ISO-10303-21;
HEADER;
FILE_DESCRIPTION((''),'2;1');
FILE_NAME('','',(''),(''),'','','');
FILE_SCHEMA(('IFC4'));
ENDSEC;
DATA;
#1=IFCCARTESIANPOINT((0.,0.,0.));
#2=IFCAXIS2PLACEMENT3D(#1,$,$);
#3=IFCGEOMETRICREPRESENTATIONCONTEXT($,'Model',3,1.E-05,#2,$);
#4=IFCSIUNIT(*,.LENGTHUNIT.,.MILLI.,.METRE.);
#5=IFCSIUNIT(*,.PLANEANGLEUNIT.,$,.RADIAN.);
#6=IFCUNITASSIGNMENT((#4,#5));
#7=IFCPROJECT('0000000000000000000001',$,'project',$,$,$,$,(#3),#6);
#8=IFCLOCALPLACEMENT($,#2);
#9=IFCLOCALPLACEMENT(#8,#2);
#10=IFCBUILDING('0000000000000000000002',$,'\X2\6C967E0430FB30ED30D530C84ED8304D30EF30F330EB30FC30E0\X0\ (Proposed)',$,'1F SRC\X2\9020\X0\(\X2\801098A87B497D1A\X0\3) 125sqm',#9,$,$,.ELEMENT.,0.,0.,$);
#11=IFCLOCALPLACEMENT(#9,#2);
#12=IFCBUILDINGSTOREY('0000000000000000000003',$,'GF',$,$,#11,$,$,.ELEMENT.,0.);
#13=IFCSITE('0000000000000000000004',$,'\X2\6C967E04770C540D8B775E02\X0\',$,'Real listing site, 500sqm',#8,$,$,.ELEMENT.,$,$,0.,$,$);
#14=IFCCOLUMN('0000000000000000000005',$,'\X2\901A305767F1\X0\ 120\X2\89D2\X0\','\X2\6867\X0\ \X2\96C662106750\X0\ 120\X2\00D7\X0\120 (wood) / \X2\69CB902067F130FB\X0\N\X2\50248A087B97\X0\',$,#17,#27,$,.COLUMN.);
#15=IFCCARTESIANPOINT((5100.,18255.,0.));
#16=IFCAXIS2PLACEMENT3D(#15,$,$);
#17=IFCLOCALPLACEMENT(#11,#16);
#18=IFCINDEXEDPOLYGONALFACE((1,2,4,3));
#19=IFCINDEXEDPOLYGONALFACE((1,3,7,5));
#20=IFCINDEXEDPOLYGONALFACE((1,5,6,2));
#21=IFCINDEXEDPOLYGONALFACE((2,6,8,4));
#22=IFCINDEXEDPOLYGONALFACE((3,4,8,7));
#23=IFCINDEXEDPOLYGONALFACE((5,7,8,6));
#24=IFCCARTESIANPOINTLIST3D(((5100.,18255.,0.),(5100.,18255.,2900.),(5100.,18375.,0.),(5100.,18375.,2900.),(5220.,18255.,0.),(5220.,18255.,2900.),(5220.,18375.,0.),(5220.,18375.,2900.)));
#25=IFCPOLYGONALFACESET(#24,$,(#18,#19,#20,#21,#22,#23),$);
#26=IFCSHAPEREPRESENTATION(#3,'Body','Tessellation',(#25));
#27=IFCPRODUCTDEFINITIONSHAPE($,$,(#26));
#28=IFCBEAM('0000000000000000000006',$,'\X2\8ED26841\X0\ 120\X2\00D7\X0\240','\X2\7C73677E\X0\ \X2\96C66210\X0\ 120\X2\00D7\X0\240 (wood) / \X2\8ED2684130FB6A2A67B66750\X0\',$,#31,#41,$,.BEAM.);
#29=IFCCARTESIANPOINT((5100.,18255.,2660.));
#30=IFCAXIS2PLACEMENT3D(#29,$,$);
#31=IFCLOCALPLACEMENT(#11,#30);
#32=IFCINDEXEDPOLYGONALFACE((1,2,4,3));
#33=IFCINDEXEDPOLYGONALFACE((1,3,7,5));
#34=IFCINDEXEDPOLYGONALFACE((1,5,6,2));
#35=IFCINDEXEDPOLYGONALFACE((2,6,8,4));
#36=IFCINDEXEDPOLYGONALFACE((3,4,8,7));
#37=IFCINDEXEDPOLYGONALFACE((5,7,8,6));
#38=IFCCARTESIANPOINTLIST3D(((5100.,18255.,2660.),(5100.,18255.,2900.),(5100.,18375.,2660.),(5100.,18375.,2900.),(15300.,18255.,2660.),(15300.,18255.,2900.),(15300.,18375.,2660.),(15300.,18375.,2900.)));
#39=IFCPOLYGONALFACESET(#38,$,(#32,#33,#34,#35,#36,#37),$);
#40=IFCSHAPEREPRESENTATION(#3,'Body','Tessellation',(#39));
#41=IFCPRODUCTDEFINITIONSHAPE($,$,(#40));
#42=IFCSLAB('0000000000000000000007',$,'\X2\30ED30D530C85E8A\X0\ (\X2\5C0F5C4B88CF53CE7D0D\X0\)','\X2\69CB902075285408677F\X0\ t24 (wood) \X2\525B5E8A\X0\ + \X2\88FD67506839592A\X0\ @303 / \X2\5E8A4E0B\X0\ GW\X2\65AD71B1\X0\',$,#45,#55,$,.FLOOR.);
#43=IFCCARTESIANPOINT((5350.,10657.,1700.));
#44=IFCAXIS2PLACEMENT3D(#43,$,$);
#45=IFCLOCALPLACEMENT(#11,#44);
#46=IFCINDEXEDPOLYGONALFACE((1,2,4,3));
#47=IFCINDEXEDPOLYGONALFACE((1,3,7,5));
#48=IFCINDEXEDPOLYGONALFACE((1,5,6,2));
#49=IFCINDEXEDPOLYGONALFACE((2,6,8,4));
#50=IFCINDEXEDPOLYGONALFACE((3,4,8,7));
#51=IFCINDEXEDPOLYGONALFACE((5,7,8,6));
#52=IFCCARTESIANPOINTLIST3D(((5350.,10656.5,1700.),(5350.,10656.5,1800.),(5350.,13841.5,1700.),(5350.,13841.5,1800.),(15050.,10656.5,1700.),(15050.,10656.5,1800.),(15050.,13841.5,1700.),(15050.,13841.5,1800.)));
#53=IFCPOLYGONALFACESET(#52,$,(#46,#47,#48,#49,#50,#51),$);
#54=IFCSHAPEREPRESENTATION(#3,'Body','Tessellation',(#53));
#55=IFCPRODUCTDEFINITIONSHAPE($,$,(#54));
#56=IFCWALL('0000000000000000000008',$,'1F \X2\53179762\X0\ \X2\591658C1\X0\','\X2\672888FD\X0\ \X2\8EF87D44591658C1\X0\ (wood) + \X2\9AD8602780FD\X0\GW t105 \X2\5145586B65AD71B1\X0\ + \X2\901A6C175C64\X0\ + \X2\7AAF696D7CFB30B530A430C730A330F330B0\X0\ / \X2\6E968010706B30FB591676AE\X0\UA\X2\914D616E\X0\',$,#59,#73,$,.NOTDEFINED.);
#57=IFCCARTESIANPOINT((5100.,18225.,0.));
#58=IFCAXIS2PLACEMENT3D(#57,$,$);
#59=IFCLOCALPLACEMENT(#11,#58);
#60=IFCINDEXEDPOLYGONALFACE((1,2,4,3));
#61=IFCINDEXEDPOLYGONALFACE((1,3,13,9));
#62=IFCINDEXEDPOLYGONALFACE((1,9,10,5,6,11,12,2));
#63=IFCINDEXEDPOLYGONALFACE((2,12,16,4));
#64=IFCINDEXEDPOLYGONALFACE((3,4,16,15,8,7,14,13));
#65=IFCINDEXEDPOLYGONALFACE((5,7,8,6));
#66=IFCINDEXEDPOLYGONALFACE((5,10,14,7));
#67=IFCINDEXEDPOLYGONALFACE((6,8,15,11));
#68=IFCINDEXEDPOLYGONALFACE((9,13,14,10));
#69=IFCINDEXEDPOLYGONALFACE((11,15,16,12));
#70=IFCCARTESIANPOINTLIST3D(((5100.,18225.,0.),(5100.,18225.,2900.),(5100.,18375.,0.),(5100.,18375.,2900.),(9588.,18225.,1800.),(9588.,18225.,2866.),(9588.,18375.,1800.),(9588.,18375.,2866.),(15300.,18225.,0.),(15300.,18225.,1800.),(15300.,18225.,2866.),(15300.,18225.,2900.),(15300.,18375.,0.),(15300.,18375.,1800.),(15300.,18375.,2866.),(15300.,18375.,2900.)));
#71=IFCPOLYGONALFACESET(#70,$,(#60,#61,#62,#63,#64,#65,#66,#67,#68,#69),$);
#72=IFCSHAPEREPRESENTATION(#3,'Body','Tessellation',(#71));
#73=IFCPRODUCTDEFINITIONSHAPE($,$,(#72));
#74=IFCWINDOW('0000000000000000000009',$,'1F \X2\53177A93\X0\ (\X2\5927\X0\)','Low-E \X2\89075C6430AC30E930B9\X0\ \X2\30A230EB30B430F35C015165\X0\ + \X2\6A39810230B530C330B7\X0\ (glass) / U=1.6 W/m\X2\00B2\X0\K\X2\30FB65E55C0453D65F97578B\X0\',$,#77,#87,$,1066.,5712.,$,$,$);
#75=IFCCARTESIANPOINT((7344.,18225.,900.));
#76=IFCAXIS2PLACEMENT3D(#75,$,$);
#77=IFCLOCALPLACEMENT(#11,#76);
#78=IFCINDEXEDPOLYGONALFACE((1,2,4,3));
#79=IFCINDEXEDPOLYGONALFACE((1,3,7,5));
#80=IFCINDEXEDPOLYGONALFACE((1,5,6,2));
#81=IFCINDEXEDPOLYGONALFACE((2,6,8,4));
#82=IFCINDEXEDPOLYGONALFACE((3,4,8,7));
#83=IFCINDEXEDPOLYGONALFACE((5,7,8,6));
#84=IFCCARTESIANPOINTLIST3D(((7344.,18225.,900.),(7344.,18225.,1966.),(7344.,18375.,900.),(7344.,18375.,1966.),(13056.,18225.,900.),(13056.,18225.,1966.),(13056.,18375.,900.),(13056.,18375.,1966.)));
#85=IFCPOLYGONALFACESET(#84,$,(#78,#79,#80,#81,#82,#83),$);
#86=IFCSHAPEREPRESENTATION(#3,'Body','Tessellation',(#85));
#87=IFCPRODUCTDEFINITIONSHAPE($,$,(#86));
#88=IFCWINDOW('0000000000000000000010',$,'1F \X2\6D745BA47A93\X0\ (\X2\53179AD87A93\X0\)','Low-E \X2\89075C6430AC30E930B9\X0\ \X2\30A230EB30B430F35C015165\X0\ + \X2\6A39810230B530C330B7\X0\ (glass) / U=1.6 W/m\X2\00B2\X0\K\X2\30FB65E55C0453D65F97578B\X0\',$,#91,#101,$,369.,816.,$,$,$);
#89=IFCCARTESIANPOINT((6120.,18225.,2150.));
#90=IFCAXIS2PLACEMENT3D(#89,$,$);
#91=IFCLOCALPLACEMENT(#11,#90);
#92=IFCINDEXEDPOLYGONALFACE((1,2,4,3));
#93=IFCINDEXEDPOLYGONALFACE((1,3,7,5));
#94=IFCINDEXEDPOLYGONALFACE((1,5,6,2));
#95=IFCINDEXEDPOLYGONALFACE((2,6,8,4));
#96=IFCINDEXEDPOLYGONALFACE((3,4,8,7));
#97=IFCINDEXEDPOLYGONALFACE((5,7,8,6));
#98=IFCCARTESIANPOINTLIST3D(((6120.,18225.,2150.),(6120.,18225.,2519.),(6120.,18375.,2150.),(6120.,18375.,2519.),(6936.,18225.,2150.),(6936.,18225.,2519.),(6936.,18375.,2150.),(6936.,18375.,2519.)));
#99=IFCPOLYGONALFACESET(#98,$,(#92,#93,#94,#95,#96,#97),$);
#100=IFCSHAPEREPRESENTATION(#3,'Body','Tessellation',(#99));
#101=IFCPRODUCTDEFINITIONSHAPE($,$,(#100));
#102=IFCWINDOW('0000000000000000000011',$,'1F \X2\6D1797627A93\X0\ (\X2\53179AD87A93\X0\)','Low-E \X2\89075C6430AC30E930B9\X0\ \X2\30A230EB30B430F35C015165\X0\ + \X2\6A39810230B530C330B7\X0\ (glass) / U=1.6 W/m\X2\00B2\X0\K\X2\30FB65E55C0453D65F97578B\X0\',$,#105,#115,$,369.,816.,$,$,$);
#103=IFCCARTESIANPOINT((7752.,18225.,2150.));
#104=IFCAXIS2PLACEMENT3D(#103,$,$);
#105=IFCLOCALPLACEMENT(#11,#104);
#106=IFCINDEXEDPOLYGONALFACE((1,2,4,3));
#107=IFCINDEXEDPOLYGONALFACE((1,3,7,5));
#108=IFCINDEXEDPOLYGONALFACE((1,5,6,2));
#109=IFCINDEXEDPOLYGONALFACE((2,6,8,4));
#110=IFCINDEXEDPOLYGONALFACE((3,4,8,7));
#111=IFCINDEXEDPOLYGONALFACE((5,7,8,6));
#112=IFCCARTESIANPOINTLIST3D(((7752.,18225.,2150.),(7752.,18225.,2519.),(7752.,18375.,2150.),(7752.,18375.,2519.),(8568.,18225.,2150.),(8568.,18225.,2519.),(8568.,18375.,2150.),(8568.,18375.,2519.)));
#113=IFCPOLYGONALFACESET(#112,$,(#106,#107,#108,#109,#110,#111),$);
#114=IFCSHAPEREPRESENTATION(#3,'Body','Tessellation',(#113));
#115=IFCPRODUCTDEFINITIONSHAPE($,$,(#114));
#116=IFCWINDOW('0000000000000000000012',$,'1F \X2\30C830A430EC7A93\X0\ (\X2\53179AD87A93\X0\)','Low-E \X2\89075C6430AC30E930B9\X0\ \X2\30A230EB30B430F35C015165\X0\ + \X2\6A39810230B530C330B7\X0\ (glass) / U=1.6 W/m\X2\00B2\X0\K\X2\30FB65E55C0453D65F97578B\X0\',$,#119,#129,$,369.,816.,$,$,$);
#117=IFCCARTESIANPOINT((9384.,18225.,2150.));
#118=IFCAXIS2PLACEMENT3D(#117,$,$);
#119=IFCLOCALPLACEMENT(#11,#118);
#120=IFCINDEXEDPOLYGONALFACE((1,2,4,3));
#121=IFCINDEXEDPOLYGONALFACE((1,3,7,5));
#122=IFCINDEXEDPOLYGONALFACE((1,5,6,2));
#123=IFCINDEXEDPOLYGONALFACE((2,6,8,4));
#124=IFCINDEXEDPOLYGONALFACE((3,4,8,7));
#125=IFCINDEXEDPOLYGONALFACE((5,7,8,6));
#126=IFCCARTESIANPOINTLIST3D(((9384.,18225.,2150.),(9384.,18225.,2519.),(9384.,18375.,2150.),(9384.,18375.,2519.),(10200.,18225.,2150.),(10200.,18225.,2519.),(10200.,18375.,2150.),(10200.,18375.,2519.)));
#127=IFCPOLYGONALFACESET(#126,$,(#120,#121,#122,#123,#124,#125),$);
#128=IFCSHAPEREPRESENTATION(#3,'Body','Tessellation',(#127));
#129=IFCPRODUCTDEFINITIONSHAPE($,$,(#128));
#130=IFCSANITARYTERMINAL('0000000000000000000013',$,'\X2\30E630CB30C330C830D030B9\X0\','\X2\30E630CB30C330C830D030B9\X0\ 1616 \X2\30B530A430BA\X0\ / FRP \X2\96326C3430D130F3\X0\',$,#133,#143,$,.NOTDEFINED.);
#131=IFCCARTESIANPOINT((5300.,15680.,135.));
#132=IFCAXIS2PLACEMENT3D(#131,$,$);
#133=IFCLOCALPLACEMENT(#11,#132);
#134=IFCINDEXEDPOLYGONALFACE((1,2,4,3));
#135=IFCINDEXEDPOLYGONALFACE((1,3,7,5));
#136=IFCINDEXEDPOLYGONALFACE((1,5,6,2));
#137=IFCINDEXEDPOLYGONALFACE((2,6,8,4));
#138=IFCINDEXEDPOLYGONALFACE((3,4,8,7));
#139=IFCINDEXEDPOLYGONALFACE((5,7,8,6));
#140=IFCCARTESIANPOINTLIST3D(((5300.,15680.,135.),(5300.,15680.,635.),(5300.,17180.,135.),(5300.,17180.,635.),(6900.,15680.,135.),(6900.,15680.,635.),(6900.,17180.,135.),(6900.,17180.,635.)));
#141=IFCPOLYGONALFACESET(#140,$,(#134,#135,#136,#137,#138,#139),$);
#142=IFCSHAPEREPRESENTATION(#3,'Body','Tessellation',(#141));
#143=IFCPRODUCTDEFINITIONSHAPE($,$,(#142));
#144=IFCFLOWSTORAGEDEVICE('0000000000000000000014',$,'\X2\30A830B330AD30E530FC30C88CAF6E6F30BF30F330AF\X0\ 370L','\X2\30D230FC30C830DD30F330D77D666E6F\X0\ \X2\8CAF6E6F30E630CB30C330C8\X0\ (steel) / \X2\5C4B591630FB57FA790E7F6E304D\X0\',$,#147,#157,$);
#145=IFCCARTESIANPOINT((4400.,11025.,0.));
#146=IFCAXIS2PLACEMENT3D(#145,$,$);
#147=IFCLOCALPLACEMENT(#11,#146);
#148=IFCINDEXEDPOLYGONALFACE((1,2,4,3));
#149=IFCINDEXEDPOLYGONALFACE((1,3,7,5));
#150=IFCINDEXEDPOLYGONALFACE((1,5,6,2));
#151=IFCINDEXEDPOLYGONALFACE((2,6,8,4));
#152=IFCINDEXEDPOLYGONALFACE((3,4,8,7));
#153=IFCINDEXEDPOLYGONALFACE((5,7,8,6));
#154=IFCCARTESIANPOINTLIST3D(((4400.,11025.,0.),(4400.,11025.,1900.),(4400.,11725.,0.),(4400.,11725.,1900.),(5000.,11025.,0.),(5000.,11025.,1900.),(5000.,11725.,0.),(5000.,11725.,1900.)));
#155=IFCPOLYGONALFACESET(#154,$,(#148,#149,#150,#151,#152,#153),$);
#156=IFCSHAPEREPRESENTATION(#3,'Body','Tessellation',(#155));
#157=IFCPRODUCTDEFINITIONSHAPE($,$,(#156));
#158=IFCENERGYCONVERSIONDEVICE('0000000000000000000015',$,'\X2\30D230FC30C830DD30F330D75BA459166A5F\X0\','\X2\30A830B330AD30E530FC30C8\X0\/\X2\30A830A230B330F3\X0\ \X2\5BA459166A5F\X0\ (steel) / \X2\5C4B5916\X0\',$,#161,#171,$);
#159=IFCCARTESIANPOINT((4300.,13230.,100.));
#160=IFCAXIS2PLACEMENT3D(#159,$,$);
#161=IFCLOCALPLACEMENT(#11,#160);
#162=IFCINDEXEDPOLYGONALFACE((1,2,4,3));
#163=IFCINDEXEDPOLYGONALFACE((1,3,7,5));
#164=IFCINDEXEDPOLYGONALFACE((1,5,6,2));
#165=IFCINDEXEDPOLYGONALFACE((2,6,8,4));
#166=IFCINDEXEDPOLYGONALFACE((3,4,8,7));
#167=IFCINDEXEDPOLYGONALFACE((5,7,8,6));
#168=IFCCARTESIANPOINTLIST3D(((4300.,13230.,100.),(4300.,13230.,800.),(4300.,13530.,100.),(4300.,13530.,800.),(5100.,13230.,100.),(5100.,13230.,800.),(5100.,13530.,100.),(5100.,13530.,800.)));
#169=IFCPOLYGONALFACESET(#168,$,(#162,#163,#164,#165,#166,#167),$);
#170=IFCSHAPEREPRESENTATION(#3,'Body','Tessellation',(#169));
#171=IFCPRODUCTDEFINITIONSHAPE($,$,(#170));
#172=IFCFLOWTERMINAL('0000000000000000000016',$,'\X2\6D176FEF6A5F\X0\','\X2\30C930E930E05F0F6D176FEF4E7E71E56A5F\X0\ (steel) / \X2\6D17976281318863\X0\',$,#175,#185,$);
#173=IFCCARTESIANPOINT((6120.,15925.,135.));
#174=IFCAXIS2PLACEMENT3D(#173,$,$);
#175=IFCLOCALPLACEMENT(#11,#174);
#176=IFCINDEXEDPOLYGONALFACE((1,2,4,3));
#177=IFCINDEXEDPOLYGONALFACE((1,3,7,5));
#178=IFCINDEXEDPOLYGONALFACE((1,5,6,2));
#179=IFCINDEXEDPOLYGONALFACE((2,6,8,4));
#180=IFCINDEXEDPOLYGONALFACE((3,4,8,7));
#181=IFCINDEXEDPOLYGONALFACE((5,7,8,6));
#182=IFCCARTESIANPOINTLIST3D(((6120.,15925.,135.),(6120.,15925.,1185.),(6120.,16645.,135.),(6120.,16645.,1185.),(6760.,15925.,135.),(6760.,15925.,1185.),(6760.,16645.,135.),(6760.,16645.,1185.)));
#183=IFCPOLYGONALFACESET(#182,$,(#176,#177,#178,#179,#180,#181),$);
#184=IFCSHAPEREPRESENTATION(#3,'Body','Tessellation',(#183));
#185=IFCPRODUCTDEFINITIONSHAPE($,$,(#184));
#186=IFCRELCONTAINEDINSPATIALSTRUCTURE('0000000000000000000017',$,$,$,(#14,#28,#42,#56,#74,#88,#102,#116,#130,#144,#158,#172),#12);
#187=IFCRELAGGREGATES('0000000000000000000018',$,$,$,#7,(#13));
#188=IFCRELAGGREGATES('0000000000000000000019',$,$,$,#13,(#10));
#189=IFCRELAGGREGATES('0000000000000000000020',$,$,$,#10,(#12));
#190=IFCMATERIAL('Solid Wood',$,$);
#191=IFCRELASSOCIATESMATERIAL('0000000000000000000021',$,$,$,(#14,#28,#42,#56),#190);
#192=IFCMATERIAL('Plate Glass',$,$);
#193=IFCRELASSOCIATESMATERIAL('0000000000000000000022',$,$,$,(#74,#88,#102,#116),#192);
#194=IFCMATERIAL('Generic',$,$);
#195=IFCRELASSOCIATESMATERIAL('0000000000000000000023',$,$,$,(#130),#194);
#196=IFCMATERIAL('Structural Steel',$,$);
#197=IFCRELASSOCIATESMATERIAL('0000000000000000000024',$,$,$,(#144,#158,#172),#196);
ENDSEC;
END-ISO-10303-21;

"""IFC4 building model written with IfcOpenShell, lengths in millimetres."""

from ifc_helpers import new_model, si_unit, frame, frame_2d, origin, place, context, project, spatial, rectangle, extrude, material, element, fill, save


model = new_model("IFC4")

# Units and contexts
model_context = context("Model", 3, precision=1e-05, world=origin())
ifc_project = project(units=[si_unit("LENGTHUNIT", "METRE", prefix="MILLI"), si_unit("PLANEANGLEUNIT", "RADIAN")], contexts=[model_context])

# Site, building, storey
site_placement = place(None, origin())
site = spatial("IfcSite", under=ifc_project, at=site_placement, Name="沖縄県名護市", ObjectType="Real listing site, 500sqm", CompositionType="ELEMENT", RefElevation=0.0)
building_placement = place(site_placement, origin())
building = spatial("IfcBuilding", under=site, at=building_placement, Name="沖縄・ロフト付きワンルーム (Proposed)", ObjectType="1F SRC造(耐風等級3) 125sqm", CompositionType="ELEMENT", ElevationOfRefHeight=0.0, ElevationOfTerrain=0.0)
storey_placement = place(building_placement, origin())
storey = spatial("IfcBuildingStorey", under=building, at=storey_placement, Name="GF", CompositionType="ELEMENT", Elevation=0.0)

# Column
ifc_material_1 = material(Name="Solid Wood")
column_1_placement = place(storey_placement, frame((5100.0, 18255.0, 0.0)))
element("IfcColumn", 1, at=column_1_placement, inside=storey, material=ifc_material_1, Name="通し柱 120角", Description="桧 集成材 120×120 (wood) / 構造柱・N値計算", PredefinedType="COLUMN", context=model_context, shape_type="SweptSolid", body=[
    extrude(rectangle(XDim=120.0, YDim=120.0, at=frame_2d((60.0, 60.0))), frame((5100.0, 18255.0, 0.0)), (0.0, 0.0, 1.0), 2900.0),
])

# Beam
beam_1_placement = place(storey_placement, frame((5100.0, 18255.0, 2660.0)))
element("IfcBeam", 2, at=beam_1_placement, inside=storey, material=ifc_material_1, Name="軒桁 120×240", Description="米松 集成 120×240 (wood) / 軒桁・横架材", PredefinedType="BEAM", context=model_context, shape_type="SweptSolid", body=[
    extrude(rectangle(XDim=10200.0, YDim=120.0, at=frame_2d((5100.0, 60.0))), frame((5100.0, 18255.0, 2660.0)), (0.0, 0.0, 1.0), 240.0),
])

# Slab
slab_placement = place(storey_placement, frame((5350.0, 10657.0, 1700.0)))
element("IfcSlab", 3, at=slab_placement, inside=storey, material=ifc_material_1, Name="ロフト床 (小屋裏収納)", Description="構造用合板 t24 (wood) 剛床 + 製材根太 @303 / 床下 GW断熱", PredefinedType="FLOOR", context=model_context, shape_type="SweptSolid", body=[
    extrude(rectangle(XDim=9700.0, YDim=3185.0, at=frame_2d((4850.0, 1592.0))), frame((5350.0, 10657.0, 1700.0)), (0.0, 0.0, 1.0), 100.0),
])

# Wall, openings, windows
wall_1_placement = place(storey_placement, frame((5100.0, 18225.0, 0.0)))
wall_1 = element("IfcWall", 4, at=wall_1_placement, inside=storey, material=ifc_material_1, Name="1F 北面 外壁", Description="木製 軸組外壁 (wood) + 高性能GW t105 充填断熱 + 通気層 + 窯業系サイディング / 準耐火・外皮UA配慮", PredefinedType="NOTDEFINED", context=model_context, shape_type="SweptSolid", body=[
    extrude(rectangle(XDim=10200.0, YDim=150.0, at=frame_2d((5100.0, 75.0))), frame((5100.0, 18225.0, 0.0)), (0.0, 0.0, 1.0), 2900.0),
])
opening_1_placement = place(storey_placement, frame((7344.0, 18225.0, 900.0)))
opening_1 = element("IfcOpeningElement", 5, at=opening_1_placement, cuts=wall_1, PredefinedType="NOTDEFINED", context=model_context, shape_type="SweptSolid", body=[
    extrude(rectangle(XDim=5712.0, YDim=150.0, at=frame_2d((2856.0, 75.0))), frame((7344.0, 18225.0, 900.0)), (0.0, 0.0, 1.0), 1066.0),
])
opening_2_placement = place(storey_placement, frame((6120.0, 18225.0, 2150.0)))
opening_2 = element("IfcOpeningElement", 6, at=opening_2_placement, cuts=wall_1, PredefinedType="NOTDEFINED", context=model_context, shape_type="SweptSolid", body=[
    extrude(rectangle(XDim=816.0, YDim=150.0, at=frame_2d((408.0, 75.0))), frame((6120.0, 18225.0, 2150.0)), (0.0, 0.0, 1.0), 369.0),
])
opening_3_placement = place(storey_placement, frame((7752.0, 18225.0, 2150.0)))
opening_3 = element("IfcOpeningElement", 7, at=opening_3_placement, cuts=wall_1, PredefinedType="NOTDEFINED", context=model_context, shape_type="SweptSolid", body=[
    extrude(rectangle(XDim=816.0, YDim=150.0, at=frame_2d((408.0, 75.0))), frame((7752.0, 18225.0, 2150.0)), (0.0, 0.0, 1.0), 369.0),
])
opening_4_placement = place(storey_placement, frame((9384.0, 18225.0, 2150.0)))
opening_4 = element("IfcOpeningElement", 8, at=opening_4_placement, cuts=wall_1, PredefinedType="NOTDEFINED", context=model_context, shape_type="SweptSolid", body=[
    extrude(rectangle(XDim=816.0, YDim=150.0, at=frame_2d((408.0, 75.0))), frame((9384.0, 18225.0, 2150.0)), (0.0, 0.0, 1.0), 369.0),
])
ifc_material_2 = material(Name="Plate Glass")
window_1_placement = place(storey_placement, frame((7344.0, 18225.0, 900.0)))
window_1 = element("IfcWindow", 9, at=window_1_placement, inside=storey, material=ifc_material_2, Name="1F 北窓 (大)", Description="Low-E 複層ガラス アルゴン封入 + 樹脂サッシ (glass) / U=1.6 W/m²K・日射取得型", OverallHeight=1066.0, OverallWidth=5712.0, context=model_context, shape_type="SweptSolid", body=[
    extrude(rectangle(XDim=5712.0, YDim=150.0, at=frame_2d((2856.0, 75.0))), frame((7344.0, 18225.0, 900.0)), (0.0, 0.0, 1.0), 1066.0),
])
fill(opening_1, window_1)
window_2_placement = place(storey_placement, frame((6120.0, 18225.0, 2150.0)))
window_2 = element("IfcWindow", 10, at=window_2_placement, inside=storey, material=ifc_material_2, Name="1F 浴室窓 (北高窓)", Description="Low-E 複層ガラス アルゴン封入 + 樹脂サッシ (glass) / U=1.6 W/m²K・日射取得型", OverallHeight=369.0, OverallWidth=816.0, context=model_context, shape_type="SweptSolid", body=[
    extrude(rectangle(XDim=816.0, YDim=150.0, at=frame_2d((408.0, 75.0))), frame((6120.0, 18225.0, 2150.0)), (0.0, 0.0, 1.0), 369.0),
])
fill(opening_2, window_2)
window_3_placement = place(storey_placement, frame((7752.0, 18225.0, 2150.0)))
window_3 = element("IfcWindow", 11, at=window_3_placement, inside=storey, material=ifc_material_2, Name="1F 洗面窓 (北高窓)", Description="Low-E 複層ガラス アルゴン封入 + 樹脂サッシ (glass) / U=1.6 W/m²K・日射取得型", OverallHeight=369.0, OverallWidth=816.0, context=model_context, shape_type="SweptSolid", body=[
    extrude(rectangle(XDim=816.0, YDim=150.0, at=frame_2d((408.0, 75.0))), frame((7752.0, 18225.0, 2150.0)), (0.0, 0.0, 1.0), 369.0),
])
fill(opening_3, window_3)
window_4_placement = place(storey_placement, frame((9384.0, 18225.0, 2150.0)))
window_4 = element("IfcWindow", 12, at=window_4_placement, inside=storey, material=ifc_material_2, Name="1F トイレ窓 (北高窓)", Description="Low-E 複層ガラス アルゴン封入 + 樹脂サッシ (glass) / U=1.6 W/m²K・日射取得型", OverallHeight=369.0, OverallWidth=816.0, context=model_context, shape_type="SweptSolid", body=[
    extrude(rectangle(XDim=816.0, YDim=150.0, at=frame_2d((408.0, 75.0))), frame((9384.0, 18225.0, 2150.0)), (0.0, 0.0, 1.0), 369.0),
])
fill(opening_4, window_4)

# Sanitary terminal
ifc_material_3 = material(Name="Generic")
sanitary_terminal_placement = place(storey_placement, frame((5300.0, 15680.0, 135.0)))
element("IfcSanitaryTerminal", 13, at=sanitary_terminal_placement, inside=storey, material=ifc_material_3, Name="ユニットバス", Description="ユニットバス 1616 サイズ / FRP 防水パン", PredefinedType="NOTDEFINED", context=model_context, shape_type="SweptSolid", body=[
    extrude(rectangle(XDim=1600.0, YDim=1500.0, at=frame_2d((800.0, 750.0))), frame((5300.0, 15680.0, 135.0)), (0.0, 0.0, 1.0), 500.0),
])

# Flow storage device
ifc_material_4 = material(Name="Structural Steel")
flow_storage_device_placement = place(storey_placement, frame((4400.0, 11025.0, 0.0)))
element("IfcFlowStorageDevice", 14, at=flow_storage_device_placement, inside=storey, material=ifc_material_4, Name="エコキュート貯湯タンク 370L", Description="ヒートポンプ給湯 貯湯ユニット (steel) / 屋外・基礎置き", context=model_context, shape_type="SweptSolid", body=[
    extrude(rectangle(XDim=600.0, YDim=700.0, at=frame_2d((300.0, 350.0))), frame((4400.0, 11025.0, 0.0)), (0.0, 0.0, 1.0), 1900.0),
])

# Energy conversion device
energy_conversion_device_placement = place(storey_placement, frame((4300.0, 13230.0, 100.0)))
element("IfcEnergyConversionDevice", 15, at=energy_conversion_device_placement, inside=storey, material=ifc_material_4, Name="ヒートポンプ室外機", Description="エコキュート/エアコン 室外機 (steel) / 屋外", context=model_context, shape_type="SweptSolid", body=[
    extrude(rectangle(XDim=800.0, YDim=300.0, at=frame_2d((400.0, 150.0))), frame((4300.0, 13230.0, 100.0)), (0.0, 0.0, 1.0), 700.0),
])

# Flow terminal
flow_terminal_placement = place(storey_placement, frame((6120.0, 15925.0, 135.0)))
element("IfcFlowTerminal", 16, at=flow_terminal_placement, inside=storey, material=ifc_material_4, Name="洗濯機", Description="ドラム式洗濯乾燥機 (steel) / 洗面脱衣", context=model_context, shape_type="SweptSolid", body=[
    extrude(rectangle(XDim=640.0, YDim=720.0, at=frame_2d((320.0, 360.0))), frame((6120.0, 15925.0, 135.0)), (0.0, 0.0, 1.0), 1050.0),
])

save(model, "model.ifc")
